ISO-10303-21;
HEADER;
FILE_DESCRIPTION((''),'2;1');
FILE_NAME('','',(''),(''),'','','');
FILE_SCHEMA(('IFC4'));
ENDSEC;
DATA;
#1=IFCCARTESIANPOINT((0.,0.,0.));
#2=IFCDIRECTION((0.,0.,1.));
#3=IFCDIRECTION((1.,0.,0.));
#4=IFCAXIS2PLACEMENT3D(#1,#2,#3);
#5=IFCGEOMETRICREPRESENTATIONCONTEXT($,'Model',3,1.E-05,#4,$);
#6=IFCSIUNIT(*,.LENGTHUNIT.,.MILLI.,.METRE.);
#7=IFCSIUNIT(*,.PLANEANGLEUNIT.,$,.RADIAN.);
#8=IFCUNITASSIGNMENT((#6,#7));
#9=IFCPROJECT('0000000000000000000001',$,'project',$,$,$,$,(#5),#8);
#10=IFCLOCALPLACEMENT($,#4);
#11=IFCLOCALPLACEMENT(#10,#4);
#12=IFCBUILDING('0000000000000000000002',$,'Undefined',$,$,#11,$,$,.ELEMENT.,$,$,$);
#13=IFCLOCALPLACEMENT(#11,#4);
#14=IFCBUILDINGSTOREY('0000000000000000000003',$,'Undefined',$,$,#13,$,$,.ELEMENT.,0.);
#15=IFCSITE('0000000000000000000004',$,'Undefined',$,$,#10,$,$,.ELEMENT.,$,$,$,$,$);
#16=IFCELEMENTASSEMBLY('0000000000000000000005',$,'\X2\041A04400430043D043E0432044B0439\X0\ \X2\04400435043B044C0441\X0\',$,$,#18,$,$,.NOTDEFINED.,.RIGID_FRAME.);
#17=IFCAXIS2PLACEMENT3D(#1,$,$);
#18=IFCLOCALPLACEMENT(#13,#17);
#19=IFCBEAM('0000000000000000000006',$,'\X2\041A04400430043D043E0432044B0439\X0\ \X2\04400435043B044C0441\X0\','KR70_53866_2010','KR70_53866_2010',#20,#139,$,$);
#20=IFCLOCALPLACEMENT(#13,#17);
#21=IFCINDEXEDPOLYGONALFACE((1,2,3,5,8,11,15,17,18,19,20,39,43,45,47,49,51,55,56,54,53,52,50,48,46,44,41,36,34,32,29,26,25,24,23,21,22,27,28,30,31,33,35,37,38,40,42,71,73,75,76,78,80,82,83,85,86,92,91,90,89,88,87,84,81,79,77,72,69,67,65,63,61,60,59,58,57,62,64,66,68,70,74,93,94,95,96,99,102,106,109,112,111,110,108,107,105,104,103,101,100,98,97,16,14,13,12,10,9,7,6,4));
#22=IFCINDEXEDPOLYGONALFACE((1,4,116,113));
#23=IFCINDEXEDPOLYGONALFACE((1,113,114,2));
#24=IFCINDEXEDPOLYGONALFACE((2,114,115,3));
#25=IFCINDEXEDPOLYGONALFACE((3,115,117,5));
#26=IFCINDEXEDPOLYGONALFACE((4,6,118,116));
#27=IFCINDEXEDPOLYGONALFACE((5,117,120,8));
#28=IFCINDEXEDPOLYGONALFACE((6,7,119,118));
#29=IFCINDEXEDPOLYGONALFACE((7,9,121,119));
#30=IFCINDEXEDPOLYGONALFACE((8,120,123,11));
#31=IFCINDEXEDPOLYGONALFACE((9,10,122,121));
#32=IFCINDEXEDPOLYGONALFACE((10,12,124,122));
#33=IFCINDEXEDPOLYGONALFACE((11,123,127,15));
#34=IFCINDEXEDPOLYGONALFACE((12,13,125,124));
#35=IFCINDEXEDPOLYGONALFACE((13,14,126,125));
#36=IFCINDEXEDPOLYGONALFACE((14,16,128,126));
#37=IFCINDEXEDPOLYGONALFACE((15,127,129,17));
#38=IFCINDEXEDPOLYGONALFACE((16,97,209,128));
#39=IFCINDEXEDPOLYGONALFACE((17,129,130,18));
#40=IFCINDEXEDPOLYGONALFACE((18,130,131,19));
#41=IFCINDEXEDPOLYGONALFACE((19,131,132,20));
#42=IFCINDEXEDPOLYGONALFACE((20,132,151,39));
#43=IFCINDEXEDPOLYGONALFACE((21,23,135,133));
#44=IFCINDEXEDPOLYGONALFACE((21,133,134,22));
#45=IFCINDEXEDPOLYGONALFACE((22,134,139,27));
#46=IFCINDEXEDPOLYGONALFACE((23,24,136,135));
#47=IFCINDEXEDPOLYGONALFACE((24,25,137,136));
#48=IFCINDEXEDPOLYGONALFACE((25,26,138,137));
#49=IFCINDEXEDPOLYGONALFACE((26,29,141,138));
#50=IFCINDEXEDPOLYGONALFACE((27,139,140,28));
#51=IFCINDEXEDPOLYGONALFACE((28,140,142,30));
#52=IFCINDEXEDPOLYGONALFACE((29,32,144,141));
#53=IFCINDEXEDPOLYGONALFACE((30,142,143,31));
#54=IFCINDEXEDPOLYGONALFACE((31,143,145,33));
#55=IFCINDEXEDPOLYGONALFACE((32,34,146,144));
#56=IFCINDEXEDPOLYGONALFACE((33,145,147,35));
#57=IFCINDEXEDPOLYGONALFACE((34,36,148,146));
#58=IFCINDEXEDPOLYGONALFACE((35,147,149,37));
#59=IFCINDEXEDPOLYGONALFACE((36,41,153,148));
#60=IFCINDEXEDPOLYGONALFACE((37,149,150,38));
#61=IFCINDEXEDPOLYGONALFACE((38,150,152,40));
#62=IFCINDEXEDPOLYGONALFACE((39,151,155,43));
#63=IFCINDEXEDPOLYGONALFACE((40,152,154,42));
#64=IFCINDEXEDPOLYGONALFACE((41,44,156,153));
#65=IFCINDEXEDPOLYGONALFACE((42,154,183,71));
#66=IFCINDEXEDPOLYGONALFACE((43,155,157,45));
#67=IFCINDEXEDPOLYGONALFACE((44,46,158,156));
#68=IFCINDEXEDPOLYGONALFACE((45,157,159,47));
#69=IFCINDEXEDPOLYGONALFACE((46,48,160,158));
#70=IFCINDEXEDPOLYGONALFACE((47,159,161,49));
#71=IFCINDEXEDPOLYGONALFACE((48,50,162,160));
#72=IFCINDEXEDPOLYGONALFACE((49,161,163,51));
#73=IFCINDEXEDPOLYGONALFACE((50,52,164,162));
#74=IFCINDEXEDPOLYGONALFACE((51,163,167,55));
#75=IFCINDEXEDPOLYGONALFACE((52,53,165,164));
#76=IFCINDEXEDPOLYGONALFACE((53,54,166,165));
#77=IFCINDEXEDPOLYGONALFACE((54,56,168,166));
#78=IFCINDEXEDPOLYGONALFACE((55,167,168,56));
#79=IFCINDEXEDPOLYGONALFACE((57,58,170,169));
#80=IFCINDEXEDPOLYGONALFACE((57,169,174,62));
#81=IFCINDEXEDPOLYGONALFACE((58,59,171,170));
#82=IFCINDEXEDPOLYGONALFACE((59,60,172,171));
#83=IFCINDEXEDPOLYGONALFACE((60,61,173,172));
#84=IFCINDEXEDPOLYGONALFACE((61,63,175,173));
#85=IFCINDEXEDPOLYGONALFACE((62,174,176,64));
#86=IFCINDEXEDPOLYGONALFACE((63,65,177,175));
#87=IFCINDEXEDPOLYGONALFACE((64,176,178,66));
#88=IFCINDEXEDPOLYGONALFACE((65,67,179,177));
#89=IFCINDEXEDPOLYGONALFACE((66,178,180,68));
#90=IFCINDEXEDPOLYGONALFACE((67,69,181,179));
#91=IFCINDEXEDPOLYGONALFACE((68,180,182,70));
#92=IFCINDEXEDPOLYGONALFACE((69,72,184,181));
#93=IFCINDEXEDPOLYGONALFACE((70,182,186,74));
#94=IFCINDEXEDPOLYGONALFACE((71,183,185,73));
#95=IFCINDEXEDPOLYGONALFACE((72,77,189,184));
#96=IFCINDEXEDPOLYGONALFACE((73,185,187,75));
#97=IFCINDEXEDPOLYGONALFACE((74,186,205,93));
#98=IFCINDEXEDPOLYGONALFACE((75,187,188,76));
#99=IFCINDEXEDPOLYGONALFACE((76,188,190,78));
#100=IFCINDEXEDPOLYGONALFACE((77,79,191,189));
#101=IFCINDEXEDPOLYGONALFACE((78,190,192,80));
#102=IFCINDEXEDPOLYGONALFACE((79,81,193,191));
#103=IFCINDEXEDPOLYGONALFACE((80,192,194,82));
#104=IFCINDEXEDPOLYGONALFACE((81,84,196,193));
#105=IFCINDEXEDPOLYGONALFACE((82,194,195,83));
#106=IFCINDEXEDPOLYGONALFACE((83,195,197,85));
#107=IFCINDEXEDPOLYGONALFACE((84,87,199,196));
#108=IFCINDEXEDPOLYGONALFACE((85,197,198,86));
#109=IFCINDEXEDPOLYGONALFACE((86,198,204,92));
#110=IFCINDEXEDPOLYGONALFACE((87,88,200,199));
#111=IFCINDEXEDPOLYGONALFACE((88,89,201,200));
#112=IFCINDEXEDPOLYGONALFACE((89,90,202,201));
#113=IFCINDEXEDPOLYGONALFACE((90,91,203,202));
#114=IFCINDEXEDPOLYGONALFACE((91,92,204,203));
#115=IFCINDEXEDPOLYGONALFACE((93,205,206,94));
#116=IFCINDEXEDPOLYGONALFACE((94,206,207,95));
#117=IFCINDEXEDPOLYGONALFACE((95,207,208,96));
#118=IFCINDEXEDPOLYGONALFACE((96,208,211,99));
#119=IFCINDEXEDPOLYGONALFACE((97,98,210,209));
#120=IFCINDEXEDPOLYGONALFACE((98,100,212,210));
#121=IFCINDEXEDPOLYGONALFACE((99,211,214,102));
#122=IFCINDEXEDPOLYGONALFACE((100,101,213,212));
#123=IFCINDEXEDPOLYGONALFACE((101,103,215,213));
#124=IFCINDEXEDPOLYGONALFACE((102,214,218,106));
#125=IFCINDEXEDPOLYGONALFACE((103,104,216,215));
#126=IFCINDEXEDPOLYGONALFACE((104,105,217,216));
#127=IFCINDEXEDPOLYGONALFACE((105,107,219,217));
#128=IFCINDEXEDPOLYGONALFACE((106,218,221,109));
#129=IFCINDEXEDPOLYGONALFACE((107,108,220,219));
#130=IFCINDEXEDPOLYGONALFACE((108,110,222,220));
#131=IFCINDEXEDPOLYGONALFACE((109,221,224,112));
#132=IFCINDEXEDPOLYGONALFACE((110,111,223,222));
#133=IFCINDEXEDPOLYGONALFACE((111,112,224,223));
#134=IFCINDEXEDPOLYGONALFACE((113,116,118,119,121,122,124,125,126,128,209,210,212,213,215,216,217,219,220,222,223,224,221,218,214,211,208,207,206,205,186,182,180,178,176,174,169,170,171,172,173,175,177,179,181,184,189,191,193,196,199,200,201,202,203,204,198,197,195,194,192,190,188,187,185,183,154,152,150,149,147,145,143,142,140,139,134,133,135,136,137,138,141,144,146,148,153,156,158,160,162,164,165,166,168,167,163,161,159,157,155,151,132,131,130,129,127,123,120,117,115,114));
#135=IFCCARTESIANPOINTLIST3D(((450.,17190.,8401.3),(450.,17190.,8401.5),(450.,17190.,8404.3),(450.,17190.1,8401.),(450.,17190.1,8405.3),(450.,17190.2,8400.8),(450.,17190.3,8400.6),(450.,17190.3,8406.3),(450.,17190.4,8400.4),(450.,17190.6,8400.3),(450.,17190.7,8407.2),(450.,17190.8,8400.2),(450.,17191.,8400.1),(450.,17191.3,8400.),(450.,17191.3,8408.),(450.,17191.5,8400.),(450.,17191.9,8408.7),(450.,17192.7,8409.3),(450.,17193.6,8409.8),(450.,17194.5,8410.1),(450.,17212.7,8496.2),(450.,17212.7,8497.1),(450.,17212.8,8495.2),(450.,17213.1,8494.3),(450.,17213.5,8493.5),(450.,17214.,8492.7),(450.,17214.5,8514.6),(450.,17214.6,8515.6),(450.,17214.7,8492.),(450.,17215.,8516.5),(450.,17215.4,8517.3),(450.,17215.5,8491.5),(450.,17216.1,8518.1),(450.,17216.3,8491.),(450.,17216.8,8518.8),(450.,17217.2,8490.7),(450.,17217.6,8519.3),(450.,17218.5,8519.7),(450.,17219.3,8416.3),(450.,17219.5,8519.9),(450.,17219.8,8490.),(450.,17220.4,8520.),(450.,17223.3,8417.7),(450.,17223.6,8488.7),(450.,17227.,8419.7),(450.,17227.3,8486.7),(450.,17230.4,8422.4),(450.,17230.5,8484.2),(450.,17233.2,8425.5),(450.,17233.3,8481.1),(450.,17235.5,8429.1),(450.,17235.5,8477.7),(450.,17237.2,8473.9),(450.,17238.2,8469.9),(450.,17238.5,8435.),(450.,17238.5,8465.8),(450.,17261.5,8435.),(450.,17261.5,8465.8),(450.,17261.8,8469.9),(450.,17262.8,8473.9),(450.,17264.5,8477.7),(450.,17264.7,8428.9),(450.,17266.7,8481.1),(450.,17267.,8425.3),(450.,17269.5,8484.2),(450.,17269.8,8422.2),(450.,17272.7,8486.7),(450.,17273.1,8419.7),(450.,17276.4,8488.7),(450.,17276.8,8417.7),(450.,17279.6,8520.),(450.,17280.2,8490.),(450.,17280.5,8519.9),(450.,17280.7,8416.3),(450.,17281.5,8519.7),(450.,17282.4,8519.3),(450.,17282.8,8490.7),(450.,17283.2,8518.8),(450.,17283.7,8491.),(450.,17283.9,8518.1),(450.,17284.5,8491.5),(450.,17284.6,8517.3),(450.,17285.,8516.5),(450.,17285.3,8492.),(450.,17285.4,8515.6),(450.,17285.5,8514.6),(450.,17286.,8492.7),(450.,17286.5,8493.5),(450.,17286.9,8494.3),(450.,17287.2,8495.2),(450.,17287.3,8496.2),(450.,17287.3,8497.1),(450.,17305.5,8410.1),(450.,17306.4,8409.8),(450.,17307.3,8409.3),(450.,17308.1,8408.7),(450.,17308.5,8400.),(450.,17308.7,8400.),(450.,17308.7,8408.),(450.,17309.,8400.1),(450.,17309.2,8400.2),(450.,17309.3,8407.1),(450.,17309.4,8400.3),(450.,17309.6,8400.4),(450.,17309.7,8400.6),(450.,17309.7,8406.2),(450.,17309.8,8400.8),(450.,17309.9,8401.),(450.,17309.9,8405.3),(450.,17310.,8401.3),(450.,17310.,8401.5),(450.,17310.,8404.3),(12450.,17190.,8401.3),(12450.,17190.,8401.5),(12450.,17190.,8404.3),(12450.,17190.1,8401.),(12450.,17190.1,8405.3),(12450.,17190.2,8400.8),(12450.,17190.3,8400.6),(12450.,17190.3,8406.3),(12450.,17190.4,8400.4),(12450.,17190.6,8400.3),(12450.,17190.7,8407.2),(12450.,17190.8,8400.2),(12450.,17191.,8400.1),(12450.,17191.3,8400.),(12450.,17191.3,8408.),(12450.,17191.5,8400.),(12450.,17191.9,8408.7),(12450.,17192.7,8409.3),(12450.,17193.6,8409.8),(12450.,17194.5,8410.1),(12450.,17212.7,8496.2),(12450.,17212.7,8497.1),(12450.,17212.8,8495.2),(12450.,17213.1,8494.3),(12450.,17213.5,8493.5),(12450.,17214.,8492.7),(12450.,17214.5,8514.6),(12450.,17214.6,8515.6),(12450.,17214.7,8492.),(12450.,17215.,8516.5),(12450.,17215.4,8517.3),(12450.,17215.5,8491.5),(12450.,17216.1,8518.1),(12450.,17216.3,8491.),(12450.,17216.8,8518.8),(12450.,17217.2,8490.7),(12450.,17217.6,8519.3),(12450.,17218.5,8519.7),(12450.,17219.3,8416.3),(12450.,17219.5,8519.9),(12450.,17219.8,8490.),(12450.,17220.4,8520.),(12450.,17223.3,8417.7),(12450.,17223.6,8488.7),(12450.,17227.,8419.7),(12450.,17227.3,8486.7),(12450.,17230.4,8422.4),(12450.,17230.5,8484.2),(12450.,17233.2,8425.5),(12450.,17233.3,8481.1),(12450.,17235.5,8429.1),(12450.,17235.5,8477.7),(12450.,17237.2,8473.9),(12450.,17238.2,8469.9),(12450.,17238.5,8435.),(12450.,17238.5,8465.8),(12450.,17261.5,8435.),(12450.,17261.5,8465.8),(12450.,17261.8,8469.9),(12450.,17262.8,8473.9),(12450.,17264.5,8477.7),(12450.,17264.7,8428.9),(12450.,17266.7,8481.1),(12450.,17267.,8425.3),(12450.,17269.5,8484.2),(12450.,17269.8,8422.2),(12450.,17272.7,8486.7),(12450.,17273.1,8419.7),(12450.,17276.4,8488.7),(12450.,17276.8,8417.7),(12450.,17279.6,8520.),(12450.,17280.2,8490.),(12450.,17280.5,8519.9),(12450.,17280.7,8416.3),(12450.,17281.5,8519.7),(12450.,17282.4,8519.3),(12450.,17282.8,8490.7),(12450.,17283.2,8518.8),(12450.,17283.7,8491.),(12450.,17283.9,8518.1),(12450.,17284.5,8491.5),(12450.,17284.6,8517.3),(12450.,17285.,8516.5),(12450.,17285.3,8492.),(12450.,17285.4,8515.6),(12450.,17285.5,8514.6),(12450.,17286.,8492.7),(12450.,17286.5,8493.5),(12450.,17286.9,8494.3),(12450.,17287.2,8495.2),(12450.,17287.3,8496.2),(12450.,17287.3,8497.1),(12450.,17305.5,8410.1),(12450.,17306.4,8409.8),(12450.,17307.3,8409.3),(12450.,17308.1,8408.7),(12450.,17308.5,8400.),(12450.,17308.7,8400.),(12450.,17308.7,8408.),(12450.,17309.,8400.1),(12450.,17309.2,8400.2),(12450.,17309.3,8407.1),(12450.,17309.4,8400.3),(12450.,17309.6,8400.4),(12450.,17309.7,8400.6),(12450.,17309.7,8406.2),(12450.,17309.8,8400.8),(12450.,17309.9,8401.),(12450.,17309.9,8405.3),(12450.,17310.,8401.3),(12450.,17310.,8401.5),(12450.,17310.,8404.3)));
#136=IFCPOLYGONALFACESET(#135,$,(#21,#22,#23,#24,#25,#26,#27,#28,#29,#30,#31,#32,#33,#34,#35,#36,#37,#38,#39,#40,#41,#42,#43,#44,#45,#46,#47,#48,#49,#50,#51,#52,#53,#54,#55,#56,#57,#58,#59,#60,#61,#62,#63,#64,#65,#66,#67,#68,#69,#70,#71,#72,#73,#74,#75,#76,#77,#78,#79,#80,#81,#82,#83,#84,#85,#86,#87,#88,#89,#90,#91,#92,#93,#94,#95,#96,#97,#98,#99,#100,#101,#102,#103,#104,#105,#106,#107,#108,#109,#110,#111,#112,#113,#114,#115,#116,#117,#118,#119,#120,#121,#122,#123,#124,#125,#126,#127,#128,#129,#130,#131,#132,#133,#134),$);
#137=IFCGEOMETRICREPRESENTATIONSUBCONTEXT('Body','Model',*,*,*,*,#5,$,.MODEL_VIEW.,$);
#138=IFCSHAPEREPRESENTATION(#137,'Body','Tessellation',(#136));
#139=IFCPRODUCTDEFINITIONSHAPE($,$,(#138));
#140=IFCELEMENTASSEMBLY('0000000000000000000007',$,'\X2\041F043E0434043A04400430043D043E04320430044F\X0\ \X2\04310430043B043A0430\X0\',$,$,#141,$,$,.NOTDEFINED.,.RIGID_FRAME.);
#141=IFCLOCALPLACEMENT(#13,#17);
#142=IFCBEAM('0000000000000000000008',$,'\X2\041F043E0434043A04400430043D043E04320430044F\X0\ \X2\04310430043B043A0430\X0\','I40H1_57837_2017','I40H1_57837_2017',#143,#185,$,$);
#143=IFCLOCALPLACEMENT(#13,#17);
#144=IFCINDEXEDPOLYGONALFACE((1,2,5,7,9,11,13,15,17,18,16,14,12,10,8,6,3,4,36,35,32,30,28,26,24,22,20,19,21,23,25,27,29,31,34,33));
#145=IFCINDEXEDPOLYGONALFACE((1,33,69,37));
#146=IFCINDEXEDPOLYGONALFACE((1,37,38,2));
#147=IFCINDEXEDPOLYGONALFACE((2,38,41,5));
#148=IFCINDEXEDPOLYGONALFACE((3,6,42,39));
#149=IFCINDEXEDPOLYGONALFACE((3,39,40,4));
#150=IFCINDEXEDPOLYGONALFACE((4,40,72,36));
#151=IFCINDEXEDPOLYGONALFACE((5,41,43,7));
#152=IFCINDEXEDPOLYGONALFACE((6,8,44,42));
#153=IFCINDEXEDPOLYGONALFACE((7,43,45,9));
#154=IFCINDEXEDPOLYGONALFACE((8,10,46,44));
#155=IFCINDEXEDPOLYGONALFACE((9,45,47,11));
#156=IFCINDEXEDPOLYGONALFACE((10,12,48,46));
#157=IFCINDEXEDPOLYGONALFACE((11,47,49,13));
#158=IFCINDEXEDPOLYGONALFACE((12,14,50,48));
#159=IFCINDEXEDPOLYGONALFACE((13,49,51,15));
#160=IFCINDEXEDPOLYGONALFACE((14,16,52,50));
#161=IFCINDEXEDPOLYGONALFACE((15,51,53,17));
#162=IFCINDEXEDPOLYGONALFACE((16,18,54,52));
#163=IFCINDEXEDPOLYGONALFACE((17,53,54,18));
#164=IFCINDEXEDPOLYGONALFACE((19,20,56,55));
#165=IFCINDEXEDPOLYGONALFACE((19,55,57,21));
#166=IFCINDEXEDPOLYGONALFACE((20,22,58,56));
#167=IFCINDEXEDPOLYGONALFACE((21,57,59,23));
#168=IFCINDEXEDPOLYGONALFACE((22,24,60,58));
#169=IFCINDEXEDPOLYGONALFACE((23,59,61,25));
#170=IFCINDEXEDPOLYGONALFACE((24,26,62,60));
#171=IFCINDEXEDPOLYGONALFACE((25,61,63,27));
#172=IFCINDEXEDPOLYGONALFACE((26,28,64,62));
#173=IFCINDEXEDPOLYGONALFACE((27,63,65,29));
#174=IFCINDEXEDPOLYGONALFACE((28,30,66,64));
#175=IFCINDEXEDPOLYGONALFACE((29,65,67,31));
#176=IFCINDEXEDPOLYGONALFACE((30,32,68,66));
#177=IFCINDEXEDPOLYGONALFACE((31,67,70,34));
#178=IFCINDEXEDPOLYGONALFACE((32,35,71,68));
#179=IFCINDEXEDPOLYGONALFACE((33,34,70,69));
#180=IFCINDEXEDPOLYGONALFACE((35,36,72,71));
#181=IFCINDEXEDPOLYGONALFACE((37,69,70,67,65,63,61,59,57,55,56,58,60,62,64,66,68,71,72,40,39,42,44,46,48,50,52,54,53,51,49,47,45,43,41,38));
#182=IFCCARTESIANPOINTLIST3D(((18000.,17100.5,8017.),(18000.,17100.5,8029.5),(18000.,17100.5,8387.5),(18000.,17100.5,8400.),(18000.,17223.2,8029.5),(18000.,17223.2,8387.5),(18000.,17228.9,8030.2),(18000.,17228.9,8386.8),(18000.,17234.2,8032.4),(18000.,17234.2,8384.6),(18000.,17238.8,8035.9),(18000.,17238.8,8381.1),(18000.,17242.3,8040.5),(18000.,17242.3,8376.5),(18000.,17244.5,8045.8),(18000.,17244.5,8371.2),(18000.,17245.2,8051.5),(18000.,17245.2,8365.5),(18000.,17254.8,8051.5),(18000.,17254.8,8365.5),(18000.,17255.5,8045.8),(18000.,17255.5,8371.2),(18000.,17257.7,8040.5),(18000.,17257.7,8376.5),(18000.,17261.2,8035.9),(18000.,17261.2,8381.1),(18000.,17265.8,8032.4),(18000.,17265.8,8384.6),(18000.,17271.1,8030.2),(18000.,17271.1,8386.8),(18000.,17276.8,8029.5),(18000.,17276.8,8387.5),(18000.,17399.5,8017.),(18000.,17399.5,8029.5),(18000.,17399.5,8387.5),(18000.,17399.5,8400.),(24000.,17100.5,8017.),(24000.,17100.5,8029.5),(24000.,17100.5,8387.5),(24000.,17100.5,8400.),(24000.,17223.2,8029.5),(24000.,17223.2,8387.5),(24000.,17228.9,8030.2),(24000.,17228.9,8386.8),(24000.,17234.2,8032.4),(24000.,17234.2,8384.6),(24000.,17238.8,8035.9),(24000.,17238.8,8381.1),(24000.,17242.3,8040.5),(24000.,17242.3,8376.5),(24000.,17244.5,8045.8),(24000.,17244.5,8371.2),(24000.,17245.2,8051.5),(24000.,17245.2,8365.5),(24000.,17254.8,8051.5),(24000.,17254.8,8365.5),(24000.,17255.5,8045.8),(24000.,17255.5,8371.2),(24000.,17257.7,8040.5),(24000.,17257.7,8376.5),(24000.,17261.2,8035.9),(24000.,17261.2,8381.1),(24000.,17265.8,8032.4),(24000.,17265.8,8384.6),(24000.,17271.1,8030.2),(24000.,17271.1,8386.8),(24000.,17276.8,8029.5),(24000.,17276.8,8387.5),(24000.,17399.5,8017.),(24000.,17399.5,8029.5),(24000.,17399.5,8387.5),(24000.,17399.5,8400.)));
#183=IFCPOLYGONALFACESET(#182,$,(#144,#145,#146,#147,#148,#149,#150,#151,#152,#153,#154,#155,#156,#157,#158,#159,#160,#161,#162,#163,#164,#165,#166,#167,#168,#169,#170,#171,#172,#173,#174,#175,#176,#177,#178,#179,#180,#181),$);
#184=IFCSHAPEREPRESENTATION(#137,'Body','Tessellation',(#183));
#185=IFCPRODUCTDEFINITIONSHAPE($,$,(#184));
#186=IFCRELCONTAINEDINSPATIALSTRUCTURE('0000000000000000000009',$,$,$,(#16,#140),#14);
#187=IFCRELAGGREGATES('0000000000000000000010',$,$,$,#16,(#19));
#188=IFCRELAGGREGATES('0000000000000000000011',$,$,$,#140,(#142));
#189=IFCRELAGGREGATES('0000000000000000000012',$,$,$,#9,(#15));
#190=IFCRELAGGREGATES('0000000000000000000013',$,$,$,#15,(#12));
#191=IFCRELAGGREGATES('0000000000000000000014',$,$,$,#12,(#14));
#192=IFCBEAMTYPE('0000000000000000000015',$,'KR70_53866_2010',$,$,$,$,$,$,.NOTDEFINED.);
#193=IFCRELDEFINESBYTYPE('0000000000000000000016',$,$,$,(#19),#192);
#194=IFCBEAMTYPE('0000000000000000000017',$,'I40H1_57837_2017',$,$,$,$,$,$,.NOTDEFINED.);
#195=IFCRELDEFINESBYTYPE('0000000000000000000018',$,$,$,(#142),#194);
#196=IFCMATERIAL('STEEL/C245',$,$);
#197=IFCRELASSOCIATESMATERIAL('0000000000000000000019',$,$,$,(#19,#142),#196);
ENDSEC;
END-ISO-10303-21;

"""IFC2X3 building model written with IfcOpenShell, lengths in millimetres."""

from ifc_helpers import new_model, si_unit, frame, origin_with_axes, origin_2d_with_axis, place, context, subcontext, project, spatial, polyline, i_section, outline, extrude, material, type_object, element, aggregate, save


model = new_model("IFC2X3")

# Units and contexts
model_context = context("Model", 3, precision=1e-05, world=origin_with_axes())
body_context = subcontext(model_context, "Body", "Model", "MODEL_VIEW")
ifc_project = project(units=[si_unit("LENGTHUNIT", "METRE", prefix="MILLI"), si_unit("PLANEANGLEUNIT", "RADIAN")], contexts=[model_context])

# Site, building, storey
site_placement = place(None, origin_with_axes())
site = spatial("IfcSite", under=ifc_project, at=site_placement, Name="Undefined", CompositionType="ELEMENT")
building_placement = place(site_placement, origin_with_axes())
building = spatial("IfcBuilding", under=site, at=building_placement, Name="Undefined", CompositionType="ELEMENT")
storey_placement = place(building_placement, origin_with_axes())
storey = spatial("IfcBuildingStorey", under=building, at=storey_placement, Name="Undefined", CompositionType="ELEMENT", Elevation=0.0)

# Shared definitions
ifc_material_1 = material(Name="STEEL/C245")

# Element assemblies, beams
assembly_1_placement = place(storey_placement, origin_with_axes())
assembly_1 = element("IfcElementAssembly", 1, at=assembly_1_placement, inside=storey, Name="Крановый рельс", AssemblyPlace="NOTDEFINED", PredefinedType="RIGID_FRAME")
beam_type_1 = type_object("IfcBeamType", Name="KR70_53866_2010", PredefinedType="NOTDEFINED")
beam_1_placement = place(assembly_1_placement, frame((12450.0, 17250.0, 8460.0), z_axis=(0.0, 0.0, 1.0), x_axis=(-1.0, 0.0, 0.0)))
beam_1 = element("IfcBeam", 2, at=beam_1_placement, type_object=beam_type_1, material=ifc_material_1, Name="Крановый рельс", Description="KR70_53866_2010", ObjectType="KR70_53866_2010", context=body_context, shape_type="SweptSolid", body=[
    extrude(outline(polyline([(58.7, -52.0), (59.3, -52.9), (59.7, -53.8), (59.9, -54.7), (60.0, -55.7), (60.0, -58.5), (60.0, -58.7), (59.9, -59.0), (59.8, -59.2), (59.7, -59.4), (59.6, -59.6), (59.4, -59.7), (59.2, -59.8), (59.0, -59.9), (58.7, -60.0), (58.5, -60.0), (-58.5, -60.0), (-58.7, -60.0), (-59.0, -59.9), (-59.2, -59.8), (-59.4, -59.7), (-59.6, -59.6), (-59.7, -59.4), (-59.8, -59.2), (-59.9, -59.0), (-60.0, -58.7), (-60.0, -58.5), (-60.0, -55.7), (-59.9, -54.7), (-59.7, -53.7), (-59.3, -52.8), (-58.7, -52.0), (-58.1, -51.3), (-57.3, -50.7), (-56.4, -50.2), (-55.5, -49.9), (-30.7, -43.7), (-26.7, -42.3), (-23.0, -40.3), (-19.6, -37.6), (-16.8, -34.5), (-14.5, -30.9), (-11.5, -25.0), (-11.5, 5.8), (-11.8, 9.9), (-12.8, 13.9), (-14.5, 17.7), (-16.7, 21.1), (-19.5, 24.2), (-22.7, 26.7), (-26.4, 28.7), (-30.2, 30.0), (-32.8, 30.7), (-33.7, 31.0), (-34.5, 31.5), (-35.3, 32.0), (-36.0, 32.7), (-36.5, 33.5), (-36.9, 34.3), (-37.2, 35.2), (-37.3, 36.2), (-37.3, 37.1), (-35.5, 54.6), (-35.4, 55.6), (-35.0, 56.5), (-34.6, 57.3), (-33.9, 58.1), (-33.2, 58.8), (-32.4, 59.3), (-31.5, 59.7), (-30.5, 59.9), (-29.6, 60.0), (29.6, 60.0), (30.5, 59.9), (31.5, 59.7), (32.4, 59.3), (33.2, 58.8), (33.9, 58.1), (34.6, 57.3), (35.0, 56.5), (35.4, 55.6), (35.5, 54.6), (37.3, 37.1), (37.3, 36.2), (37.2, 35.2), (36.9, 34.3), (36.5, 33.5), (36.0, 32.7), (35.3, 32.0), (34.5, 31.5), (33.7, 31.0), (32.8, 30.7), (30.2, 30.0), (26.4, 28.7), (22.7, 26.7), (19.5, 24.2), (16.7, 21.1), (14.5, 17.7), (12.8, 13.9), (11.8, 9.9), (11.5, 5.8), (11.5, -25.0), (14.7, -31.1), (17.0, -34.7), (19.8, -37.8), (23.1, -40.3), (26.8, -42.3), (30.7, -43.7), (55.5, -49.9), (56.4, -50.2), (57.3, -50.7), (58.1, -51.3), (58.7, -52.0)])), frame((12000.0, 0.0, 0.0), z_axis=(-1.0, 0.0, 0.0), x_axis=(0.0, -1.0, 0.0)), (0.0, 0.0, 1.0), 12000.0),
])
aggregate(assembly_1, [beam_1])
assembly_2_placement = place(storey_placement, origin_with_axes())
assembly_2 = element("IfcElementAssembly", 3, at=assembly_2_placement, inside=storey, Name="Подкрановая балка", AssemblyPlace="NOTDEFINED", PredefinedType="RIGID_FRAME")
beam_type_2 = type_object("IfcBeamType", Name="I40H1_57837_2017", PredefinedType="NOTDEFINED")
beam_2_placement = place(assembly_2_placement, frame((24000.0, 17250.0, 8208.5), z_axis=(0.0, 0.0, 1.0), x_axis=(-1.0, 0.0, 0.0)))
beam_2 = element("IfcBeam", 4, at=beam_2_placement, type_object=beam_type_2, material=ifc_material_1, Name="Подкрановая балка", Description="I40H1_57837_2017", ObjectType="I40H1_57837_2017", context=body_context, shape_type="SweptSolid", body=[
    extrude(i_section(OverallWidth=299.0, OverallDepth=383.0, WebThickness=9.5, FlangeThickness=12.5, FilletRadius=22.0, at=origin_2d_with_axis()), frame((6000.0, 0.0, 0.0), z_axis=(-1.0, 0.0, 0.0), x_axis=(0.0, -1.0, 0.0)), (0.0, 0.0, 1.0), 6000.0),
])
aggregate(assembly_2, [beam_2])

save(model, "model.ifc")
